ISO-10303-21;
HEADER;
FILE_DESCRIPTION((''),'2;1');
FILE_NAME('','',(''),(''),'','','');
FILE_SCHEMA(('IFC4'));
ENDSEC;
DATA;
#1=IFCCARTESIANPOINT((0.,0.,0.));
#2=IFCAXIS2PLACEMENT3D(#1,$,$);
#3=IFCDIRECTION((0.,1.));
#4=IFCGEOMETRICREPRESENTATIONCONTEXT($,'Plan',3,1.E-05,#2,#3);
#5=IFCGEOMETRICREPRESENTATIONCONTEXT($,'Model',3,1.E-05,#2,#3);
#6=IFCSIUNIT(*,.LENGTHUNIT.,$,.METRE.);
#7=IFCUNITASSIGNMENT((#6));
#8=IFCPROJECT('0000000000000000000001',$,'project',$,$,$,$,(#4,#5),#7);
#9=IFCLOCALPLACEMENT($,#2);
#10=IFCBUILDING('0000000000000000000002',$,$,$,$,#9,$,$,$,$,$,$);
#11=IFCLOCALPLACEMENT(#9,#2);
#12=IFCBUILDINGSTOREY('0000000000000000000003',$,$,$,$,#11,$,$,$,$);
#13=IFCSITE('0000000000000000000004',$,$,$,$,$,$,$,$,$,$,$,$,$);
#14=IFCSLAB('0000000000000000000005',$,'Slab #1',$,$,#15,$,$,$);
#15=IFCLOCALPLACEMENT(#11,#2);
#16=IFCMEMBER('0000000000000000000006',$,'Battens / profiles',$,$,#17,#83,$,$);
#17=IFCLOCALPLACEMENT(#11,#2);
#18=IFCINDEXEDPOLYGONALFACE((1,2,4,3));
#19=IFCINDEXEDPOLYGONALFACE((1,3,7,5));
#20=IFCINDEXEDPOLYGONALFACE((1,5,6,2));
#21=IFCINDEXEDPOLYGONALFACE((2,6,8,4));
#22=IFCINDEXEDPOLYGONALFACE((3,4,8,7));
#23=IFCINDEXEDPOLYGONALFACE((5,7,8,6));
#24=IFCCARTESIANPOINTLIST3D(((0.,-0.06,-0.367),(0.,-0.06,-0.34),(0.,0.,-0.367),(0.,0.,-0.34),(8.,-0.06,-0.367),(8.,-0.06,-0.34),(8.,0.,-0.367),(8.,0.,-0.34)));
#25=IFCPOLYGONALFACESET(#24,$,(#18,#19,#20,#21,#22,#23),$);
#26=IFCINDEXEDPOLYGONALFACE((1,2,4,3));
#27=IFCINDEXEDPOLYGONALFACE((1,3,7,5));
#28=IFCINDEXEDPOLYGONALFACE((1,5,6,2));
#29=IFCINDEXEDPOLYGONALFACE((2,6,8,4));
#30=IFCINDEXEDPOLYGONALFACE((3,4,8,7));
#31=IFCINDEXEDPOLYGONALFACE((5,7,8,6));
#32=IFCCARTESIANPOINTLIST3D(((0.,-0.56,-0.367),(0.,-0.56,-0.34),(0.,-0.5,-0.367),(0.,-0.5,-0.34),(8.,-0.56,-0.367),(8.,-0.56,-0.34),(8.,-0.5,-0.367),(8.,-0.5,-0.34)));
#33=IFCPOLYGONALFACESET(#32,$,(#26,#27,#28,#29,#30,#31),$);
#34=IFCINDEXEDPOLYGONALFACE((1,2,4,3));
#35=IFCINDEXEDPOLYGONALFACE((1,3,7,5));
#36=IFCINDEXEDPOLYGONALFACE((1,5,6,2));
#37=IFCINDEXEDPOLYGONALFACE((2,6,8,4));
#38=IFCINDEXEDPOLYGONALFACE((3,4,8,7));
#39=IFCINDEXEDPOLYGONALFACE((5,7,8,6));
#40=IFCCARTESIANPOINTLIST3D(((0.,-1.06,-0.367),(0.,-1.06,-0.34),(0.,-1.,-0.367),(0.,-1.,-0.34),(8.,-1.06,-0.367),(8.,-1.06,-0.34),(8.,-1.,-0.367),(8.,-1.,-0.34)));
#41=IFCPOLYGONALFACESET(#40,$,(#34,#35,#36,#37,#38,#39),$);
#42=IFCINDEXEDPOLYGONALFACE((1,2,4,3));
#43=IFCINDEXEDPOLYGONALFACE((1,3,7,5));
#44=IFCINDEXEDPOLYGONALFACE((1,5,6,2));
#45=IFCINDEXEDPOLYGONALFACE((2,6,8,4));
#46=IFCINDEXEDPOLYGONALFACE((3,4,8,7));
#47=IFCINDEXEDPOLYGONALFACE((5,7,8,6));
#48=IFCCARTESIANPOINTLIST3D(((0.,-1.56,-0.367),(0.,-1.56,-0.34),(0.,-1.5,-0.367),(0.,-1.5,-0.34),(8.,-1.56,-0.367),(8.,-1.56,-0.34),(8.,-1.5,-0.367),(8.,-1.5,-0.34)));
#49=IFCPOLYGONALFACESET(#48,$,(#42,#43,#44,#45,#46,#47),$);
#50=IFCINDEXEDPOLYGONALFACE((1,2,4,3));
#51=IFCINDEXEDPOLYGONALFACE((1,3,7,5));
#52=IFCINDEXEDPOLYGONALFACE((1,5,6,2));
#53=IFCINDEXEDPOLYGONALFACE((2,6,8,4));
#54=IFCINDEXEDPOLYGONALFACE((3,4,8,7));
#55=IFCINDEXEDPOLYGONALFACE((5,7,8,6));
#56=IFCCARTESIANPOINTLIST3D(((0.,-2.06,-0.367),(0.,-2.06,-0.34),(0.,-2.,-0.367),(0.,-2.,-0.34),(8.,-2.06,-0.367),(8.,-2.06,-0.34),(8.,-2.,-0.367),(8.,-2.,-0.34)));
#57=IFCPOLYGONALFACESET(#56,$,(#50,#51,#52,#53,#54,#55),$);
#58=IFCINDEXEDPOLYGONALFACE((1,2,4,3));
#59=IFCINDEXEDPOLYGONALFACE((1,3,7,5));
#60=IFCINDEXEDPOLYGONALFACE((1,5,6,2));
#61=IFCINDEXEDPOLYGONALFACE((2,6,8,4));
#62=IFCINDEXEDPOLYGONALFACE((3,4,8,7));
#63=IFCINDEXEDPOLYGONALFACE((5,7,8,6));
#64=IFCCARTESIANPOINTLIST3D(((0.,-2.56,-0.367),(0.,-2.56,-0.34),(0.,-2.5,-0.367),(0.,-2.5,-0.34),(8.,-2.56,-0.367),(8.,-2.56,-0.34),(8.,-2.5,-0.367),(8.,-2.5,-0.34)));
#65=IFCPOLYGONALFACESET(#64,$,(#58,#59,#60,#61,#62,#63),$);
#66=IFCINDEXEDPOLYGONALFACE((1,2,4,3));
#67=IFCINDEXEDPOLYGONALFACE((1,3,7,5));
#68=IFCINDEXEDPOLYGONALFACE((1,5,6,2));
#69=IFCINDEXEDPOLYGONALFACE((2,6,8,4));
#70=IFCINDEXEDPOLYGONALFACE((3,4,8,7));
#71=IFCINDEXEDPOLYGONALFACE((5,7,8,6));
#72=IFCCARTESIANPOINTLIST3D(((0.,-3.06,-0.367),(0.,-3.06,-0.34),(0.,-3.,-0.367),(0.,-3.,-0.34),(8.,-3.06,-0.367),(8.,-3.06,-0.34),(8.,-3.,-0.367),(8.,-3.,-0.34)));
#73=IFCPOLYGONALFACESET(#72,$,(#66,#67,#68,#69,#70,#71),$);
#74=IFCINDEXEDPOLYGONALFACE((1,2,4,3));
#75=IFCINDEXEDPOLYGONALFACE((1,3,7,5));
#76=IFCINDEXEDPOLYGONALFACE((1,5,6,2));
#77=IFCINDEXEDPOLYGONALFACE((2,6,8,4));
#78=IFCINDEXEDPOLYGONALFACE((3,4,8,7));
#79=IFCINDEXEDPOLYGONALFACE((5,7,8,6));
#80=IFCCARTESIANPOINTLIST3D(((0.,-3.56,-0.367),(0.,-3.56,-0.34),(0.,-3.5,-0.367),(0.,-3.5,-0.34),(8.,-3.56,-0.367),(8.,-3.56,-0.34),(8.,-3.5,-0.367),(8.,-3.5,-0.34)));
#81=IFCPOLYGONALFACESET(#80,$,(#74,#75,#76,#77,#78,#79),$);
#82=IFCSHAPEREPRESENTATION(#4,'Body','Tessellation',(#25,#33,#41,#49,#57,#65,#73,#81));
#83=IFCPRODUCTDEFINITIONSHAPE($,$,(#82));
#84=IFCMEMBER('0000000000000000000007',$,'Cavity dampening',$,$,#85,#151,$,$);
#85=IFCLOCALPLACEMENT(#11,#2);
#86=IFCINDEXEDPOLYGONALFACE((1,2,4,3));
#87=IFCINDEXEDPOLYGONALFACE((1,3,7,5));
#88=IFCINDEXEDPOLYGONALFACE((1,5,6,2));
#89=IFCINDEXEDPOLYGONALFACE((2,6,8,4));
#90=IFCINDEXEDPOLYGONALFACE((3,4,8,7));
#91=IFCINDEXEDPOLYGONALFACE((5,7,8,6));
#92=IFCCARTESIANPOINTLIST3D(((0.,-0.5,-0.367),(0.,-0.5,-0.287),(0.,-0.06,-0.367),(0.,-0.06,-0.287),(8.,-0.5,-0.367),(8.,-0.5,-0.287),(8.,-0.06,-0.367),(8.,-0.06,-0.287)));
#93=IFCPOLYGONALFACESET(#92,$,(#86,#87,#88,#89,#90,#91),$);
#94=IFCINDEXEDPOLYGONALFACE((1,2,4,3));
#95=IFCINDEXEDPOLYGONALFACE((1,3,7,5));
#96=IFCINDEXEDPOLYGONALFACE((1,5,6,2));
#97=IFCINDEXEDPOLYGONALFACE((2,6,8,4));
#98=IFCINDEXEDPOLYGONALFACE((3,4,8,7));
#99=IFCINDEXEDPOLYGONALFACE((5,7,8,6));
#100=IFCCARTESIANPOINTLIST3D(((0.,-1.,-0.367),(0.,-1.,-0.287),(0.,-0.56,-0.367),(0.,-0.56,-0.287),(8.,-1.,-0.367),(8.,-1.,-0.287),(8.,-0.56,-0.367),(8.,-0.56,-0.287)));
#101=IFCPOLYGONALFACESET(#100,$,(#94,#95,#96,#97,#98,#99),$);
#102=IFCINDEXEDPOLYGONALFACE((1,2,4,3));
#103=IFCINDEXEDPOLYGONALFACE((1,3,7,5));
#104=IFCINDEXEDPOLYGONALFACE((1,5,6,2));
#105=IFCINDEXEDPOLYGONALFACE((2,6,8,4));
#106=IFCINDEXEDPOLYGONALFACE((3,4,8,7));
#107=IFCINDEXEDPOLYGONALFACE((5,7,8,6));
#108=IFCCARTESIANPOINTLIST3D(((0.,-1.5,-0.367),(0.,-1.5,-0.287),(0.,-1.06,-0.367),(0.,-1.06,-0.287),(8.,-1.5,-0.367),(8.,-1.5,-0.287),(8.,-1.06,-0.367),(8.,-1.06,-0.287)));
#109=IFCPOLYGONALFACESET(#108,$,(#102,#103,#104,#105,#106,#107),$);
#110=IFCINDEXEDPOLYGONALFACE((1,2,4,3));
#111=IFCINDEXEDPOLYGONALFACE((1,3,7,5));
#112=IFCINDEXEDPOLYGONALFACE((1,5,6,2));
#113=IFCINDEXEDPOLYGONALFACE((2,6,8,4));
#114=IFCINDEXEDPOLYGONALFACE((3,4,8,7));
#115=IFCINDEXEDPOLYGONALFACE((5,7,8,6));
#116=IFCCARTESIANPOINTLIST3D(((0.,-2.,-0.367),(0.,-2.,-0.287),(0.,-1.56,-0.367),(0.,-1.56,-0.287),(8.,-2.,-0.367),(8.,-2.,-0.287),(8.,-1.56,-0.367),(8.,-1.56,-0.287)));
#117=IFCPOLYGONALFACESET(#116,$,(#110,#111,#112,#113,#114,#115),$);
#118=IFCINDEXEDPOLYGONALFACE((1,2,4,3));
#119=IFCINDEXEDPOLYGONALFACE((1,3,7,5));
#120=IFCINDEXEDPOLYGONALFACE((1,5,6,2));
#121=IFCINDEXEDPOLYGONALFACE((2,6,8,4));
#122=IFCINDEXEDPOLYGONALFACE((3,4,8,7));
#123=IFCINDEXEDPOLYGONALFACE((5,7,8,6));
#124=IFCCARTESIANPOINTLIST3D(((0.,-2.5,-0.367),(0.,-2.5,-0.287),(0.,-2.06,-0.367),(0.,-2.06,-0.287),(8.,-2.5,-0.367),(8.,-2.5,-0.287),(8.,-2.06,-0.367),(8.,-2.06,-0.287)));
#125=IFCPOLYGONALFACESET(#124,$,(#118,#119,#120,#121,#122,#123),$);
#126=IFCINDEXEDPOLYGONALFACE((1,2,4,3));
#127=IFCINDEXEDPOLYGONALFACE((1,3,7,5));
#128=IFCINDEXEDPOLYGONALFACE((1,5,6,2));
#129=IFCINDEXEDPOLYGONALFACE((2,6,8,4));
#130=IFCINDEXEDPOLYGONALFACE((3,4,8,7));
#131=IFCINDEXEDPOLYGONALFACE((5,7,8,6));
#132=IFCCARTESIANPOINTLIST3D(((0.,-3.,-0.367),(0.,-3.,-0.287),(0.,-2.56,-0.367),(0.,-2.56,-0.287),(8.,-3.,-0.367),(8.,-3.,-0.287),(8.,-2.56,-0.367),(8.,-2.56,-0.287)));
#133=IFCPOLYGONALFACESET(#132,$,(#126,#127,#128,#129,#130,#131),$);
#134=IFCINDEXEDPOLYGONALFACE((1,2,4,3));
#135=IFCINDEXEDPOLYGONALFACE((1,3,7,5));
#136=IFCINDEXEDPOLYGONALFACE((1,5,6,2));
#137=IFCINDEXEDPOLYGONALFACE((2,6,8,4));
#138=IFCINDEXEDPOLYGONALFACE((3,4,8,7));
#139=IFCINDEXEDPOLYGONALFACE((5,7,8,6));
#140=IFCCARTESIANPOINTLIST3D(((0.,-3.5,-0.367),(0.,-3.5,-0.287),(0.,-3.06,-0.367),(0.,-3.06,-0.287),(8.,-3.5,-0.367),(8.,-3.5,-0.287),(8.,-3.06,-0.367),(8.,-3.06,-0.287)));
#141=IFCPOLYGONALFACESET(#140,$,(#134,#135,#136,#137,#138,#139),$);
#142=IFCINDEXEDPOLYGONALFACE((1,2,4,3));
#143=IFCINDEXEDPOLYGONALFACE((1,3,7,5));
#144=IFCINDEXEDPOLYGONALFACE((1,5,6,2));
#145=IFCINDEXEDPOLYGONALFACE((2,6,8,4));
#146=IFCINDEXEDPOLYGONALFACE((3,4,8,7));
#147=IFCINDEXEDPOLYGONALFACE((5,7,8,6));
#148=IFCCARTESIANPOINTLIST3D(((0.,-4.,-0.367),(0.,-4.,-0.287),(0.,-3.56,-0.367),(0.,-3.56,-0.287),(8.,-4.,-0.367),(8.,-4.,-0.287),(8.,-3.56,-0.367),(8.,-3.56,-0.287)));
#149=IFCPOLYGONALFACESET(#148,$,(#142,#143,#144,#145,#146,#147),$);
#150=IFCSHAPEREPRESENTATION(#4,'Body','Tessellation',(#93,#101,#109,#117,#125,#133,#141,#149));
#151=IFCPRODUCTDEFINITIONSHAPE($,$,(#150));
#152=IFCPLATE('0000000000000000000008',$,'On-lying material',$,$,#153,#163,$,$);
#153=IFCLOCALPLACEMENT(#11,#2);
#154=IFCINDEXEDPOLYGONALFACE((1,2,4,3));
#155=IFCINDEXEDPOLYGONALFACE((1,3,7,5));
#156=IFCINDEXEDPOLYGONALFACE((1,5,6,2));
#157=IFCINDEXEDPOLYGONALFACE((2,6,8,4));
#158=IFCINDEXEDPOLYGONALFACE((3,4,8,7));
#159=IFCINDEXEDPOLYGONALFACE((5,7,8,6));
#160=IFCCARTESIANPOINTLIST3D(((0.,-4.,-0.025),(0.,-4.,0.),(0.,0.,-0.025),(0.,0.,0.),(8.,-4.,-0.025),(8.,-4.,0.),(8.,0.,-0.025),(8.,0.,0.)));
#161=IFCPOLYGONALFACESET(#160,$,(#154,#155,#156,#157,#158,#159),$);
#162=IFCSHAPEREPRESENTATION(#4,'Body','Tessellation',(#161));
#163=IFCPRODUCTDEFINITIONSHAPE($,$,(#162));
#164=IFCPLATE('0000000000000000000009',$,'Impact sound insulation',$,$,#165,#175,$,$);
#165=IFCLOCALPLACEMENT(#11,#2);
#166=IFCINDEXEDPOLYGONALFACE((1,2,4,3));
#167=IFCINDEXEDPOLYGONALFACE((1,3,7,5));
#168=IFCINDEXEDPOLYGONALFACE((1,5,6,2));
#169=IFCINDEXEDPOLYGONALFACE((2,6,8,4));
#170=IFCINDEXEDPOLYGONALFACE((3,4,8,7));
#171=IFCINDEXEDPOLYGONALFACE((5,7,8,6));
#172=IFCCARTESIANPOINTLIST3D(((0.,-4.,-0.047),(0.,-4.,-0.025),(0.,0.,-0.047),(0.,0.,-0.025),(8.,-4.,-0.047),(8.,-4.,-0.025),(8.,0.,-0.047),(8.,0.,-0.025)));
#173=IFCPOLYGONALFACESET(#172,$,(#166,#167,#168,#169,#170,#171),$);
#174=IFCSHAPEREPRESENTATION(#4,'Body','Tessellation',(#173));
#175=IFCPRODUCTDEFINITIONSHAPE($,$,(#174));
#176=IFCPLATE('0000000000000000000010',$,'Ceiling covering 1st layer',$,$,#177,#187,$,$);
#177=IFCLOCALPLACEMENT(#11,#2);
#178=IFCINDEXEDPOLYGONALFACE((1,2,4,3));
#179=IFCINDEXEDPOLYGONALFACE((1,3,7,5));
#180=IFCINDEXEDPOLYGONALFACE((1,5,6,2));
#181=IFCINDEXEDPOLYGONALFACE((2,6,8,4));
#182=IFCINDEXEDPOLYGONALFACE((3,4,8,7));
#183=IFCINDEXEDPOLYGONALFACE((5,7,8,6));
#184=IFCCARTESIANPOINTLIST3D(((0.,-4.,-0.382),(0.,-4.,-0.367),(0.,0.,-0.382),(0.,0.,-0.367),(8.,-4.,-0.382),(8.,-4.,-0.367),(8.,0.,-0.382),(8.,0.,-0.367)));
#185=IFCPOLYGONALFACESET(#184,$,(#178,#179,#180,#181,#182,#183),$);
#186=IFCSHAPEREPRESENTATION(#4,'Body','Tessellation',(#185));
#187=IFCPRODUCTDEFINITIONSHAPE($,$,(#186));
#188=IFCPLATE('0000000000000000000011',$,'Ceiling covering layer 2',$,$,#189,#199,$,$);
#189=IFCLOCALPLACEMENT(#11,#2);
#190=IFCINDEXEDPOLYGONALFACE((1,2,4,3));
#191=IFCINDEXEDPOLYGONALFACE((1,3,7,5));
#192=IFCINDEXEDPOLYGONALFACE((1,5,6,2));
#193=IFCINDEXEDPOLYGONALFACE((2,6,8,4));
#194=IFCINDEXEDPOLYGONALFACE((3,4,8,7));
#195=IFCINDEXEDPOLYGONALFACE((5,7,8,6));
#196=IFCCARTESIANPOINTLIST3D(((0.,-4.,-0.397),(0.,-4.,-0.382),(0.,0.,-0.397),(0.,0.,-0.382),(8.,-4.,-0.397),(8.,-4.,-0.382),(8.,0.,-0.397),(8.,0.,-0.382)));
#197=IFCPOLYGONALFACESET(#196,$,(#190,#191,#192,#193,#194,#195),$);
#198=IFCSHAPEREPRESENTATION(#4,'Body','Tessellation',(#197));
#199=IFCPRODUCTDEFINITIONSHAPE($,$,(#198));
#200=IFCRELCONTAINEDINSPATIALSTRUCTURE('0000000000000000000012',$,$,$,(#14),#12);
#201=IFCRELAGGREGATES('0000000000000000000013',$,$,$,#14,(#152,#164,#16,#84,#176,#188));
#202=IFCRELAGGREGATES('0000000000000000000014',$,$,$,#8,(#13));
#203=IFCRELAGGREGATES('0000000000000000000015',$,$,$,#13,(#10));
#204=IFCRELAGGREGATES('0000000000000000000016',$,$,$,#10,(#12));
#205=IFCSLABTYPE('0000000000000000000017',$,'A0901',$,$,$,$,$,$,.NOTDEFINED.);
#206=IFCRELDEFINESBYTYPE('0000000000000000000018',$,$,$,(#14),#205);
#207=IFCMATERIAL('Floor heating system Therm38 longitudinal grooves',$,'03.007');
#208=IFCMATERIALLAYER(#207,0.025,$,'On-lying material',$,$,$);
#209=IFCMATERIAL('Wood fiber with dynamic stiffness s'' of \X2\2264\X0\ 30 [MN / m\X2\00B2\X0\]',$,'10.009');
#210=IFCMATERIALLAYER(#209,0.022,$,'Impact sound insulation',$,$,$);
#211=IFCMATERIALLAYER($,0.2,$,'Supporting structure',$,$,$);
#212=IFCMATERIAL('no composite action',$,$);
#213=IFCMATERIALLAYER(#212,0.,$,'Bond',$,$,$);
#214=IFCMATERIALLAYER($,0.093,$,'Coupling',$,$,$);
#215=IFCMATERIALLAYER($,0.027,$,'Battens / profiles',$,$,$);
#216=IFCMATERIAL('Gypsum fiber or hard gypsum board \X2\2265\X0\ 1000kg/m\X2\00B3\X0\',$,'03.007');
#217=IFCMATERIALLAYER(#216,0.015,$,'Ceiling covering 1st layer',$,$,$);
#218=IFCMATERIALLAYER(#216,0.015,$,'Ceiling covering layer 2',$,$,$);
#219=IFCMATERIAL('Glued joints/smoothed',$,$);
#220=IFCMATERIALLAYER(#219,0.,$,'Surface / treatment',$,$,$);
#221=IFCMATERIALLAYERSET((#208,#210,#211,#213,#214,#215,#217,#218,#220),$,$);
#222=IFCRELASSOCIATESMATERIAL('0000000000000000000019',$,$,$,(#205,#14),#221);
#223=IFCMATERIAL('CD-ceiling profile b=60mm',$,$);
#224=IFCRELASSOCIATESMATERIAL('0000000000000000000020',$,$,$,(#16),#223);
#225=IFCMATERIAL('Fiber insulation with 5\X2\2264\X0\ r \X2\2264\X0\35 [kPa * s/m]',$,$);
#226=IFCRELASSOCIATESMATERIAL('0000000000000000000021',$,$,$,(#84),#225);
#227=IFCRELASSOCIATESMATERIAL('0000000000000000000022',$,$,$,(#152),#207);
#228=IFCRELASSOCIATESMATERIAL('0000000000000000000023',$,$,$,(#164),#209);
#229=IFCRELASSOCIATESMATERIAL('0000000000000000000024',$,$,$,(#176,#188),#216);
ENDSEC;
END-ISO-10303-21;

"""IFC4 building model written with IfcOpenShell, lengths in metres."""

from ifc_helpers import new_model, si_unit, direction, frame, frame_2d, origin, origin_with_axes, place, context, project, spatial, rectangle, extrude, material, layer, layer_set, type_object, element, aggregate, save


model = new_model("IFC4")

# Units and contexts
plan_context = context("Plan", 3, precision=1e-05, world=origin(), true_north=direction((0.0, 1.0)))
model_context = context("Model", 3, precision=1e-05, world=origin(), true_north=direction((0.0, 1.0)))
ifc_project = project(units=[si_unit("LENGTHUNIT", "METRE")], contexts=[plan_context, model_context])

# Site, building, storey
site = spatial("IfcSite", under=ifc_project)
building_placement = place(None, origin())
building = spatial("IfcBuilding", under=site, at=building_placement)
storey_placement = place(building_placement, origin())
storey = spatial("IfcBuildingStorey", under=building, at=storey_placement)

# Slab, members, plates
ifc_material_1 = material(Name="Floor heating system Therm38 longitudinal grooves", Category="03.007")
ifc_layer_1 = layer(ifc_material_1, 0.025, Name="On-lying material")
ifc_material_2 = material(Name="Wood fiber with dynamic stiffness s' of ≤ 30 [MN / m²]", Category="10.009")
ifc_layer_2 = layer(ifc_material_2, 0.022, Name="Impact sound insulation")
ifc_layer_3 = layer(None, 0.2, Name="Supporting structure")
ifc_material_3 = material(Name="no composite action")
ifc_layer_4 = layer(ifc_material_3, 0.0, Name="Bond")
ifc_layer_5 = layer(None, 0.093, Name="Coupling")
ifc_layer_6 = layer(None, 0.027, Name="Battens / profiles")
ifc_material_4 = material(Name="Gypsum fiber or hard gypsum board ≥ 1000kg/m³", Category="03.007")
ifc_layer_7 = layer(ifc_material_4, 0.015, Name="Ceiling covering 1st layer")
ifc_layer_8 = layer(ifc_material_4, 0.015, Name="Ceiling covering layer 2")
ifc_material_5 = material(Name="Glued joints/smoothed")
ifc_layer_9 = layer(ifc_material_5, 0.0, Name="Surface / treatment")
ifc_layer_set = layer_set([ifc_layer_1, ifc_layer_2, ifc_layer_3, ifc_layer_4, ifc_layer_5, ifc_layer_6, ifc_layer_7, ifc_layer_8, ifc_layer_9])
slab_type = type_object("IfcSlabType", Name="A0901", PredefinedType="NOTDEFINED", material=ifc_layer_set)
slab_placement = place(None, frame((0.0, 0.0, 0.0), z_axis=(0.0, 0.0, -1.0), x_axis=(1.0, 0.0, 0.0)))
slab = element("IfcSlab", 1, at=slab_placement, inside=storey, type_object=slab_type, material=ifc_layer_set, Name="Slab #1")
ifc_material_6 = material(Name="CD-ceiling profile b=60mm")
member_1_placement = place(slab_placement, origin())
member_1 = element("IfcMember", 2, at=member_1_placement, material=ifc_material_6, Name="Battens / profiles", context=plan_context, shape_type="SweptSolid", body=[
    extrude(rectangle(XDim=0.06, YDim=0.027, at=frame_2d((0.03, 0.0135), x_axis=(1.0, 0.0))), frame((0.0, 0.0, 0.34), z_axis=(1.0, 0.0, 0.0), x_axis=(0.0, 1.0, 0.0)), (0.0, 0.0, 1.0), 8.0),
    extrude(rectangle(XDim=0.06, YDim=0.027, at=frame_2d((0.03, 0.0135), x_axis=(1.0, 0.0))), frame((0.0, 0.5, 0.34), z_axis=(1.0, 0.0, 0.0), x_axis=(0.0, 1.0, 0.0)), (0.0, 0.0, 1.0), 8.0),
    extrude(rectangle(XDim=0.06, YDim=0.027, at=frame_2d((0.03, 0.0135), x_axis=(1.0, 0.0))), frame((0.0, 1.0, 0.34), z_axis=(1.0, 0.0, 0.0), x_axis=(0.0, 1.0, 0.0)), (0.0, 0.0, 1.0), 8.0),
    extrude(rectangle(XDim=0.06, YDim=0.027, at=frame_2d((0.03, 0.0135), x_axis=(1.0, 0.0))), frame((0.0, 1.5, 0.34), z_axis=(1.0, 0.0, 0.0), x_axis=(0.0, 1.0, 0.0)), (0.0, 0.0, 1.0), 8.0),
    extrude(rectangle(XDim=0.06, YDim=0.027, at=frame_2d((0.03, 0.0135), x_axis=(1.0, 0.0))), frame((0.0, 2.0, 0.34), z_axis=(1.0, 0.0, 0.0), x_axis=(0.0, 1.0, 0.0)), (0.0, 0.0, 1.0), 8.0),
    extrude(rectangle(XDim=0.06, YDim=0.027, at=frame_2d((0.03, 0.0135), x_axis=(1.0, 0.0))), frame((0.0, 2.5, 0.34), z_axis=(1.0, 0.0, 0.0), x_axis=(0.0, 1.0, 0.0)), (0.0, 0.0, 1.0), 8.0),
    extrude(rectangle(XDim=0.06, YDim=0.027, at=frame_2d((0.03, 0.0135), x_axis=(1.0, 0.0))), frame((0.0, 3.0, 0.34), z_axis=(1.0, 0.0, 0.0), x_axis=(0.0, 1.0, 0.0)), (0.0, 0.0, 1.0), 8.0),
    extrude(rectangle(XDim=0.06, YDim=0.027, at=frame_2d((0.03, 0.0135), x_axis=(1.0, 0.0))), frame((0.0, 3.5, 0.34), z_axis=(1.0, 0.0, 0.0), x_axis=(0.0, 1.0, 0.0)), (0.0, 0.0, 1.0), 8.0),
])
ifc_material_7 = material(Name="Fiber insulation with 5≤ r ≤35 [kPa * s/m]")
member_2_placement = place(slab_placement, origin())
member_2 = element("IfcMember", 3, at=member_2_placement, material=ifc_material_7, Name="Cavity dampening", context=plan_context, shape_type="SweptSolid", body=[
    extrude(rectangle(XDim=0.44, YDim=0.08, at=frame_2d((0.22, 0.04), x_axis=(1.0, 0.0))), frame((0.0, 0.06, 0.287), z_axis=(1.0, 0.0, 0.0), x_axis=(0.0, 1.0, 0.0)), (0.0, 0.0, 1.0), 8.0),
    extrude(rectangle(XDim=0.44, YDim=0.08, at=frame_2d((0.22, 0.04), x_axis=(1.0, 0.0))), frame((0.0, 0.56, 0.287), z_axis=(1.0, 0.0, 0.0), x_axis=(0.0, 1.0, 0.0)), (0.0, 0.0, 1.0), 8.0),
    extrude(rectangle(XDim=0.44, YDim=0.08, at=frame_2d((0.22, 0.04), x_axis=(1.0, 0.0))), frame((0.0, 1.06, 0.287), z_axis=(1.0, 0.0, 0.0), x_axis=(0.0, 1.0, 0.0)), (0.0, 0.0, 1.0), 8.0),
    extrude(rectangle(XDim=0.44, YDim=0.08, at=frame_2d((0.22, 0.04), x_axis=(1.0, 0.0))), frame((0.0, 1.56, 0.287), z_axis=(1.0, 0.0, 0.0), x_axis=(0.0, 1.0, 0.0)), (0.0, 0.0, 1.0), 8.0),
    extrude(rectangle(XDim=0.44, YDim=0.08, at=frame_2d((0.22, 0.04), x_axis=(1.0, 0.0))), frame((0.0, 2.06, 0.287), z_axis=(1.0, 0.0, 0.0), x_axis=(0.0, 1.0, 0.0)), (0.0, 0.0, 1.0), 8.0),
    extrude(rectangle(XDim=0.44, YDim=0.08, at=frame_2d((0.22, 0.04), x_axis=(1.0, 0.0))), frame((0.0, 2.56, 0.287), z_axis=(1.0, 0.0, 0.0), x_axis=(0.0, 1.0, 0.0)), (0.0, 0.0, 1.0), 8.0),
    extrude(rectangle(XDim=0.44, YDim=0.08, at=frame_2d((0.22, 0.04), x_axis=(1.0, 0.0))), frame((0.0, 3.06, 0.287), z_axis=(1.0, 0.0, 0.0), x_axis=(0.0, 1.0, 0.0)), (0.0, 0.0, 1.0), 8.0),
    extrude(rectangle(XDim=0.44, YDim=0.08, at=frame_2d((0.22, 0.04), x_axis=(1.0, 0.0))), frame((0.0, 3.56, 0.287), z_axis=(1.0, 0.0, 0.0), x_axis=(0.0, 1.0, 0.0)), (0.0, 0.0, 1.0), 8.0),
])
plate_1_placement = place(slab_placement, origin())
plate_1 = element("IfcPlate", 4, at=plate_1_placement, material=ifc_material_1, Name="On-lying material", context=plan_context, shape_type="SweptSolid", body=[
    extrude(rectangle(XDim=8.0, YDim=4.0, at=frame_2d((4.0, 2.0), x_axis=(1.0, 0.0))), origin_with_axes(), (0.0, 0.0, 1.0), 0.025),
])
plate_2_placement = place(slab_placement, origin())
plate_2 = element("IfcPlate", 5, at=plate_2_placement, material=ifc_material_2, Name="Impact sound insulation", context=plan_context, shape_type="SweptSolid", body=[
    extrude(rectangle(XDim=8.0, YDim=4.0, at=frame_2d((4.0, 2.0), x_axis=(1.0, 0.0))), frame((0.0, 0.0, 0.025), z_axis=(0.0, 0.0, 1.0), x_axis=(1.0, 0.0, 0.0)), (0.0, 0.0, 1.0), 0.022),
])
plate_3_placement = place(slab_placement, origin())
plate_3 = element("IfcPlate", 6, at=plate_3_placement, material=ifc_material_4, Name="Ceiling covering 1st layer", context=plan_context, shape_type="SweptSolid", body=[
    extrude(rectangle(XDim=8.0, YDim=4.0, at=frame_2d((4.0, 2.0), x_axis=(1.0, 0.0))), frame((0.0, 0.0, 0.367), z_axis=(0.0, 0.0, 1.0), x_axis=(1.0, 0.0, 0.0)), (0.0, 0.0, 1.0), 0.015),
])
plate_4_placement = place(slab_placement, origin())
plate_4 = element("IfcPlate", 7, at=plate_4_placement, material=ifc_material_4, Name="Ceiling covering layer 2", context=plan_context, shape_type="SweptSolid", body=[
    extrude(rectangle(XDim=8.0, YDim=4.0, at=frame_2d((4.0, 2.0), x_axis=(1.0, 0.0))), frame((0.0, 0.0, 0.382), z_axis=(0.0, 0.0, 1.0), x_axis=(1.0, 0.0, 0.0)), (0.0, 0.0, 1.0), 0.015),
])
aggregate(slab, [plate_1, plate_2, member_1, member_2, plate_3, plate_4])

save(model, "model.ifc")
